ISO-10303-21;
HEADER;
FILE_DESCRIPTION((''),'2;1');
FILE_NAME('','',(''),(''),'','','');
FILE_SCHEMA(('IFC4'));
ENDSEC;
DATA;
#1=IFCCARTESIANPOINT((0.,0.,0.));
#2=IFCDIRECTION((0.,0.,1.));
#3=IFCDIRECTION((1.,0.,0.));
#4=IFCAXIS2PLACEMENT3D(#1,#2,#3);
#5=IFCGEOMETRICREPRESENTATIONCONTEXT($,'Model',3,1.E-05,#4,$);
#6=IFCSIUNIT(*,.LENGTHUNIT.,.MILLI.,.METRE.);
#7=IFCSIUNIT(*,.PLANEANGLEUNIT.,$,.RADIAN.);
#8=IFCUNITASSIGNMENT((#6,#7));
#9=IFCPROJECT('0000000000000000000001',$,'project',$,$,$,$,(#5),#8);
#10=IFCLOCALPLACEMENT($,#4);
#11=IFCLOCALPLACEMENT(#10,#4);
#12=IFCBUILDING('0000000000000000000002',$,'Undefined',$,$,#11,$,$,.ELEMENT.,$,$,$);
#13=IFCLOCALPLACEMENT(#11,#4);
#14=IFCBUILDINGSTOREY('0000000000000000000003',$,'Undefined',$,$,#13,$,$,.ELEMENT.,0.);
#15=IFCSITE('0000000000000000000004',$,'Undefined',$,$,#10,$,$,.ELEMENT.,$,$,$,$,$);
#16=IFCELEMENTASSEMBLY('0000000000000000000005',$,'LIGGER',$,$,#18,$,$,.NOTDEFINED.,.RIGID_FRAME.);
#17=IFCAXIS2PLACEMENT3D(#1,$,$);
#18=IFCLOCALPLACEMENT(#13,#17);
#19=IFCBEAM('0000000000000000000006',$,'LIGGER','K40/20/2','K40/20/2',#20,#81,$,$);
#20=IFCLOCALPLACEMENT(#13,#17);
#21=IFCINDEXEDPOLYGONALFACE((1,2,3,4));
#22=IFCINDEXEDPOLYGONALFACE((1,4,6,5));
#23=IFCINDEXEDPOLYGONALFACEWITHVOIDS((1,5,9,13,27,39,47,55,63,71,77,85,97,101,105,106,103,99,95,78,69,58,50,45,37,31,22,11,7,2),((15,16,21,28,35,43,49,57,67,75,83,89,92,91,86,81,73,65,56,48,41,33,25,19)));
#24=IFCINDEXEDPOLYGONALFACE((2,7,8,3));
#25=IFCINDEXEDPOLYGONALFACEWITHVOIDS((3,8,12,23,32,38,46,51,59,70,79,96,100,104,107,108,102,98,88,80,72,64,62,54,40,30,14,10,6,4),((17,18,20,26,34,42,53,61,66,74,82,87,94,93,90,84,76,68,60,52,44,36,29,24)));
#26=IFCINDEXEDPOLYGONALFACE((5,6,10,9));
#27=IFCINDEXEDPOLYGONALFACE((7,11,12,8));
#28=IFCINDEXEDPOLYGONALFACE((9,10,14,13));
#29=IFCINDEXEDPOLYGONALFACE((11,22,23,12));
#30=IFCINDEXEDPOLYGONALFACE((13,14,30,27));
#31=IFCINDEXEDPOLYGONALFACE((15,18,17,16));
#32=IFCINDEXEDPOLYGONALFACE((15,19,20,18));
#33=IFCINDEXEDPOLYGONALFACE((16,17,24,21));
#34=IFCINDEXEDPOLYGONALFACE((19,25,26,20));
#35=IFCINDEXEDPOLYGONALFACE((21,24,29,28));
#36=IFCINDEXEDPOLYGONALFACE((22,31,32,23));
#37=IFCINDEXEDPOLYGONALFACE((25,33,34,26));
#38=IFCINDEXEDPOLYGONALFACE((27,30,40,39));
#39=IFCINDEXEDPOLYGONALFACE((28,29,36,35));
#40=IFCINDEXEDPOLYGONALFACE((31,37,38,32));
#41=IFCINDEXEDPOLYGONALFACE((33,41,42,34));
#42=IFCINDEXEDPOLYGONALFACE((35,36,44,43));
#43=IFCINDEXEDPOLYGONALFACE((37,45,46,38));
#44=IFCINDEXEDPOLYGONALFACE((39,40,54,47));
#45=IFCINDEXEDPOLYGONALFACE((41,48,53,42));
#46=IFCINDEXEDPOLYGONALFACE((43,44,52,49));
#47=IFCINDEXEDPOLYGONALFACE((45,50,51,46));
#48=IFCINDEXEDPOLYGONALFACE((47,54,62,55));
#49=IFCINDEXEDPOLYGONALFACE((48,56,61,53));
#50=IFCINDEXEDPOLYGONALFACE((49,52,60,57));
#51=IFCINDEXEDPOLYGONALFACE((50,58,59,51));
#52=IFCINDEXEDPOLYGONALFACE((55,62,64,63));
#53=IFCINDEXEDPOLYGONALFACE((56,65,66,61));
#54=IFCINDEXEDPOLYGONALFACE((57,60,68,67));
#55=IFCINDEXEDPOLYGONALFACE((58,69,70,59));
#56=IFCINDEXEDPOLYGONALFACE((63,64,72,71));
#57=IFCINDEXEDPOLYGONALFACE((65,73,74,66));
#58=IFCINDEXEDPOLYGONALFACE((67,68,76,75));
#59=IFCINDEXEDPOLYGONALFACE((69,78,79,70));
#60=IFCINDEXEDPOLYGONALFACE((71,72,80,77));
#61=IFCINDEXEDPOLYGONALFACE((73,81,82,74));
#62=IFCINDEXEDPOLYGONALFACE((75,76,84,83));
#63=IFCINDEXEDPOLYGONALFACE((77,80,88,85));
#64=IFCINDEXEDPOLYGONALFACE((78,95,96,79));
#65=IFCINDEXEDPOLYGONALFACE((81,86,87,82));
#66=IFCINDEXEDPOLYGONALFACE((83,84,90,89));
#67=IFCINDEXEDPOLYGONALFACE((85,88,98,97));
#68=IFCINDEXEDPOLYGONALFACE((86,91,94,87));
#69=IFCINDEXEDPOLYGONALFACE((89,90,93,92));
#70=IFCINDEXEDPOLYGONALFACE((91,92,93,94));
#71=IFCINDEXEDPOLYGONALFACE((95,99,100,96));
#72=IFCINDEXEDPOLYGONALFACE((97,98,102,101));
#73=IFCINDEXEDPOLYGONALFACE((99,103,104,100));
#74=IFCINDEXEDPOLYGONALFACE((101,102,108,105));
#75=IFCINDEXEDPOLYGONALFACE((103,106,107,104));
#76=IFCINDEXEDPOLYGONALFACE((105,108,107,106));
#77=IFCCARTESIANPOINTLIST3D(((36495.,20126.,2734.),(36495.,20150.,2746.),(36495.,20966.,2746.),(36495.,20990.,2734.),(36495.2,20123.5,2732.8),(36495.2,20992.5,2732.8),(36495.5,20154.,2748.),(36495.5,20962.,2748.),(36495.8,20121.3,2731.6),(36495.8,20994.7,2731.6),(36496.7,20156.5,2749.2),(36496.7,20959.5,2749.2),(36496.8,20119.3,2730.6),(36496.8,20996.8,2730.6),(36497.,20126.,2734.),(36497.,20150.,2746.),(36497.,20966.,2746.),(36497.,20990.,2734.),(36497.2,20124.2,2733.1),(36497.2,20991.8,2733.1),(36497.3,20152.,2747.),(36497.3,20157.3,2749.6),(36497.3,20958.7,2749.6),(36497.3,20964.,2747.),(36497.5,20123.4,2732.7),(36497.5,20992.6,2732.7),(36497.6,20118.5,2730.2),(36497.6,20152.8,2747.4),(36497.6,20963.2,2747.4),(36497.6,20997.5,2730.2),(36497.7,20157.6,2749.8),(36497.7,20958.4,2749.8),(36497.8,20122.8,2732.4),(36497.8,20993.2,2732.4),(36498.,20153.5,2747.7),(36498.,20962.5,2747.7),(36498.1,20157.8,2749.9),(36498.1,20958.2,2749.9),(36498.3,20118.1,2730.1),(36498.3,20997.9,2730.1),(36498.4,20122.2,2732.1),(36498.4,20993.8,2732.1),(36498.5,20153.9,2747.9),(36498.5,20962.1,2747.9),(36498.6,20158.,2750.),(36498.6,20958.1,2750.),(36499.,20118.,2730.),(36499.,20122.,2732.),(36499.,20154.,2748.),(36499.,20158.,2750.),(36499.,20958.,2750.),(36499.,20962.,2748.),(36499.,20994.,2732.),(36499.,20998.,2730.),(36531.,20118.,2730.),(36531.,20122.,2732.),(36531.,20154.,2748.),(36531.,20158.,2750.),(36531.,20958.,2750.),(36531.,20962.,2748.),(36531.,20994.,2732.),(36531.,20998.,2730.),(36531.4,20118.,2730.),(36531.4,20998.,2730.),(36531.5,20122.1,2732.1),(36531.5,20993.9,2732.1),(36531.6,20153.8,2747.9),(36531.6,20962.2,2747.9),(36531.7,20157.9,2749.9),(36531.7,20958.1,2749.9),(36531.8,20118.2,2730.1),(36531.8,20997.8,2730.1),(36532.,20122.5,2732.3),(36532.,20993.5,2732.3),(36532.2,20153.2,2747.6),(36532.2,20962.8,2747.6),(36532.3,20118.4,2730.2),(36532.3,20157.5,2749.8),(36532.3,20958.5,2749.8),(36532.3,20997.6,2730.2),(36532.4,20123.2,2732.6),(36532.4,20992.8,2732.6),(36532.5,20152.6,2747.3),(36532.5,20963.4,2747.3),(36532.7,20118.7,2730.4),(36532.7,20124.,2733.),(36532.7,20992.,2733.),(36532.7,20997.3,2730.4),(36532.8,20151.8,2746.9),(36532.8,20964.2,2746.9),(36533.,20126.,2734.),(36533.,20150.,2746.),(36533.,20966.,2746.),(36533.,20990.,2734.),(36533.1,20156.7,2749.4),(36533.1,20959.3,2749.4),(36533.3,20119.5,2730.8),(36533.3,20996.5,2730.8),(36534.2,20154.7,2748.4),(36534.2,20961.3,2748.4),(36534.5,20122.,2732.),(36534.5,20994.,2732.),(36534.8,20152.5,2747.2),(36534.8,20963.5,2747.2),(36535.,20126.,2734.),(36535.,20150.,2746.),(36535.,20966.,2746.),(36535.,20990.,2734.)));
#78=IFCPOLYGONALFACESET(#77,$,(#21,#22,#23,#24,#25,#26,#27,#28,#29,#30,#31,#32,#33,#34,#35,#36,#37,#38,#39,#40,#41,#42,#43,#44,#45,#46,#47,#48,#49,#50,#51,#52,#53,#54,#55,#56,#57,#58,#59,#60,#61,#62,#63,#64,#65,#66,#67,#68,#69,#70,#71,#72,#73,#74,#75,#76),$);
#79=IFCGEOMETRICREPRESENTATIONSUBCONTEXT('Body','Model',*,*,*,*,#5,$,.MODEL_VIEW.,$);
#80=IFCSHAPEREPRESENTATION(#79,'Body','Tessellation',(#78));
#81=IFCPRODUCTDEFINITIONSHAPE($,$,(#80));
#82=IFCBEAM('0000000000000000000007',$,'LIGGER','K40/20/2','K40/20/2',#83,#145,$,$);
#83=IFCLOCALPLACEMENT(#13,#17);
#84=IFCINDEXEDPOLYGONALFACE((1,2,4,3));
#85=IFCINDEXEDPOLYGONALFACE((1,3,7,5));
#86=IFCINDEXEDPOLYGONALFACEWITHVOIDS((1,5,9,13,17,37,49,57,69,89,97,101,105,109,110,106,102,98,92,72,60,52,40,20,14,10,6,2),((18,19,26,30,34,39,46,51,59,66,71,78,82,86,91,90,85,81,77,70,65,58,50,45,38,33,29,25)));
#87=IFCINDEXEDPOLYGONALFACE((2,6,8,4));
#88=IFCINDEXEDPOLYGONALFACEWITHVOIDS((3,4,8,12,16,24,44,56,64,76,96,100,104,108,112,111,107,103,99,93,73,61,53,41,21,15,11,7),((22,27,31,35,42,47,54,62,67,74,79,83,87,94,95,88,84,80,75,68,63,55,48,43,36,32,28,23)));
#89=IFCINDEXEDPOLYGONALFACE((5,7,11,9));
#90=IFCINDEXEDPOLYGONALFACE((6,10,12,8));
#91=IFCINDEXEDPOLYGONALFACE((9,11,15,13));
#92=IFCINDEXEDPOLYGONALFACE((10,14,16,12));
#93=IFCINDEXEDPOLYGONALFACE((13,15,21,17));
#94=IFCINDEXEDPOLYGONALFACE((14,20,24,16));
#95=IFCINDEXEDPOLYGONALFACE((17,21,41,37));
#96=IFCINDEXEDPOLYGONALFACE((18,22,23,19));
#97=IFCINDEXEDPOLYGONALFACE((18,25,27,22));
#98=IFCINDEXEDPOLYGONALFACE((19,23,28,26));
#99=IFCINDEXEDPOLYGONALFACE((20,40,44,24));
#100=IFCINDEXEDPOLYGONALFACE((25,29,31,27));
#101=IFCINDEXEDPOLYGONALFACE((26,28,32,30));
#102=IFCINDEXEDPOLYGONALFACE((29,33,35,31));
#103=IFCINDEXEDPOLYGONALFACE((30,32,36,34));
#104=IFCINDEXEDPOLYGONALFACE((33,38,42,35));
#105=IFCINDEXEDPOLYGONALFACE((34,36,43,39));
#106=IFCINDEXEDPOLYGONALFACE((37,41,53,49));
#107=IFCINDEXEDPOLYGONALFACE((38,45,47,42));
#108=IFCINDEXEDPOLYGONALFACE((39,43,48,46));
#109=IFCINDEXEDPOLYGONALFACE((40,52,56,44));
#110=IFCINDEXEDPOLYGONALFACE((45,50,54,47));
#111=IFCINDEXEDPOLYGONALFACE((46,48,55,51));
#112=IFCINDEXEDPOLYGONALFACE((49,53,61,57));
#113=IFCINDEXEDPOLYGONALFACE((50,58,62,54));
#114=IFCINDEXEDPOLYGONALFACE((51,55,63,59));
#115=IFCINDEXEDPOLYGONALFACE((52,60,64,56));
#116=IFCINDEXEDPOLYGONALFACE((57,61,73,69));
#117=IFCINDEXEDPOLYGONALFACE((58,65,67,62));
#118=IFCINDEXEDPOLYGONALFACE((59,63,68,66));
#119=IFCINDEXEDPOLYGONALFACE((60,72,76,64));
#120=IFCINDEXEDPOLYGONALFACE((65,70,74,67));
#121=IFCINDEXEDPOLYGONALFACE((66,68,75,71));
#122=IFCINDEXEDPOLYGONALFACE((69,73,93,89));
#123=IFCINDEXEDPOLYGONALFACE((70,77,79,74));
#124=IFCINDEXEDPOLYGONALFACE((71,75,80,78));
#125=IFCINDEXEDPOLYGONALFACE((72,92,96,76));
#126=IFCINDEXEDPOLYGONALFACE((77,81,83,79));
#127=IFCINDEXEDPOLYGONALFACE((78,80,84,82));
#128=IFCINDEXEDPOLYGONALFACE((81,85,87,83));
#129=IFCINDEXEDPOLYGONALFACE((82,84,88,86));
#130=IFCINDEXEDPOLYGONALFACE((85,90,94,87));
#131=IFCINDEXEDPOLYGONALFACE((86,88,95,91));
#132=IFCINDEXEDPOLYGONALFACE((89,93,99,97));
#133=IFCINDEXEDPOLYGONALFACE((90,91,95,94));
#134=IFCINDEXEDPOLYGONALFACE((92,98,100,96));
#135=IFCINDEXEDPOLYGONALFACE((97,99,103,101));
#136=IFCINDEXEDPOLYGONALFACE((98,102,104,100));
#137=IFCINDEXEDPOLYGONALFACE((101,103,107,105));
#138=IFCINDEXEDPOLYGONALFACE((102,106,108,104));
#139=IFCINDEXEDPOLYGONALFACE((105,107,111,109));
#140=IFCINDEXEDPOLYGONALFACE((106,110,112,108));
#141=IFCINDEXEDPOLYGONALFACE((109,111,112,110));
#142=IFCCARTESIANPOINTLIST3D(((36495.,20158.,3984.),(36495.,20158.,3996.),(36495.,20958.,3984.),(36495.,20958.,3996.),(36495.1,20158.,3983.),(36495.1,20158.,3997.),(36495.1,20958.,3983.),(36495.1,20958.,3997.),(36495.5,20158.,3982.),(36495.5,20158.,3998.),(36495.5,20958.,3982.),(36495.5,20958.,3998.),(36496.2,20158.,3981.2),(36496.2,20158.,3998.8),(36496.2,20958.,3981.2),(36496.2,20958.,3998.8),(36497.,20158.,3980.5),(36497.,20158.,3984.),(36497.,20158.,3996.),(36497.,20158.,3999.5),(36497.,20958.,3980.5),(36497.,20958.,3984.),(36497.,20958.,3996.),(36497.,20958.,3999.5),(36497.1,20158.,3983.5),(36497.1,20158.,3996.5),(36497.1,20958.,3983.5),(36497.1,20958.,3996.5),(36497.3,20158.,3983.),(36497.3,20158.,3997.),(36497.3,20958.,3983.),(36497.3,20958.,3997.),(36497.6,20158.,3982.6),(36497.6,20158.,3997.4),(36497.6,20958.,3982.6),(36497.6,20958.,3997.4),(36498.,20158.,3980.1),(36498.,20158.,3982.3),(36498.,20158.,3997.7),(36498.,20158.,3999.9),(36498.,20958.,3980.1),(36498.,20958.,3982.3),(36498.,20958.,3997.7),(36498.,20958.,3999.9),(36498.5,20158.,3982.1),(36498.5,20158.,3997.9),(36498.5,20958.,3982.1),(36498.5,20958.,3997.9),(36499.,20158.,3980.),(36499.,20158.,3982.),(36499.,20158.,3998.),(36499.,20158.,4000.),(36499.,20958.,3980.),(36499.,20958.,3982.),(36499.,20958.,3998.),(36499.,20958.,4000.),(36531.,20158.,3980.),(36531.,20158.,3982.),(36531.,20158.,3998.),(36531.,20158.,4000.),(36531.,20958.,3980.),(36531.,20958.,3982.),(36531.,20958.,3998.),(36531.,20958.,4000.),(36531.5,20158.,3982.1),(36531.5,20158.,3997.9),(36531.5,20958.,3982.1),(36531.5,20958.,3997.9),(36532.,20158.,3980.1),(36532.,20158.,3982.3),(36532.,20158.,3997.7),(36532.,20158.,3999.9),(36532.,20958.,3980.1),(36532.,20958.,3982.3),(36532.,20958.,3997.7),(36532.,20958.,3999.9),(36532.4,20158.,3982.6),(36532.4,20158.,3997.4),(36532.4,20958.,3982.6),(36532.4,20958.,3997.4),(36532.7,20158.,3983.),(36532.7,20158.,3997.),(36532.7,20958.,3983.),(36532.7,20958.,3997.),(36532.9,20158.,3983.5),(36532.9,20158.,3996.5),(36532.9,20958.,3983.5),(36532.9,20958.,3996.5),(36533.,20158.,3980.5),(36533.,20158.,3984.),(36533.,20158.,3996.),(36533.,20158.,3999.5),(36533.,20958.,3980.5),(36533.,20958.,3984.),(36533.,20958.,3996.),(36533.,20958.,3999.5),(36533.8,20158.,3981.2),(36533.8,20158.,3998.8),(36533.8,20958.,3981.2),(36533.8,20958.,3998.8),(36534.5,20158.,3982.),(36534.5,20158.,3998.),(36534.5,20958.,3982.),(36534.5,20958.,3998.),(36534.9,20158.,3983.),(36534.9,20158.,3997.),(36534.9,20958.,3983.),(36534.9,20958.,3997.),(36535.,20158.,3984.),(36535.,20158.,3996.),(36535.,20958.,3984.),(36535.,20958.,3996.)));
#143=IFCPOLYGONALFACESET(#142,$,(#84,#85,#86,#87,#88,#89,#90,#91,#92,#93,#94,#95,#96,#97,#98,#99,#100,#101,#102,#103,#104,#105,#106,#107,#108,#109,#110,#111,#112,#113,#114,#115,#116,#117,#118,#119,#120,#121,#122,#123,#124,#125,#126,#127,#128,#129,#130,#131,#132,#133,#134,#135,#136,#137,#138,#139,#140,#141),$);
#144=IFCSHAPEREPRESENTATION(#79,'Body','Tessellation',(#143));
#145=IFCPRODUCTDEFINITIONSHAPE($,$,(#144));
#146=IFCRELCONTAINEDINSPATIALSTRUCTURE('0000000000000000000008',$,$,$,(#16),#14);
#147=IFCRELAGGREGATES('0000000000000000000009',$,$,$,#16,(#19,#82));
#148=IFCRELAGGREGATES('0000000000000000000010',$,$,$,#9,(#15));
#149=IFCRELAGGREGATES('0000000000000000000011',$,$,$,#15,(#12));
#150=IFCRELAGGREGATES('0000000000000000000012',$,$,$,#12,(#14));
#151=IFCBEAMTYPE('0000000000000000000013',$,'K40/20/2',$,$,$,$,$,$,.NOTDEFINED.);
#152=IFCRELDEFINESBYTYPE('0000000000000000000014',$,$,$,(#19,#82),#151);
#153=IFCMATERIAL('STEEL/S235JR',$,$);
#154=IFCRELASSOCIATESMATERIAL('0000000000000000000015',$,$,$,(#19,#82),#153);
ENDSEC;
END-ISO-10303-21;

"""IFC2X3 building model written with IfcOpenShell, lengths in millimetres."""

from ifc_helpers import new_model, si_unit, frame, origin_with_axes, origin_2d_with_axis, place, context, subcontext, project, spatial, hollow_rectangle, extrude, clip, halfspace, material, type_object, element, aggregate, save


model = new_model("IFC2X3")

# Units and contexts
model_context = context("Model", 3, precision=1e-05, world=origin_with_axes())
body_context = subcontext(model_context, "Body", "Model", "MODEL_VIEW")
ifc_project = project(units=[si_unit("LENGTHUNIT", "METRE", prefix="MILLI"), si_unit("PLANEANGLEUNIT", "RADIAN")], contexts=[model_context])

# Site, building, storey
site_placement = place(None, origin_with_axes())
site = spatial("IfcSite", under=ifc_project, at=site_placement, Name="Undefined", CompositionType="ELEMENT")
building_placement = place(site_placement, origin_with_axes())
building = spatial("IfcBuilding", under=site, at=building_placement, Name="Undefined", CompositionType="ELEMENT")
storey_placement = place(building_placement, origin_with_axes())
storey = spatial("IfcBuildingStorey", under=building, at=storey_placement, Name="Undefined", CompositionType="ELEMENT", Elevation=0.0)

# Element assembly, beams
ifc_material_1 = material(Name="STEEL/S235JR")
assembly_1_placement = place(storey_placement, origin_with_axes())
assembly_1 = element("IfcElementAssembly", 1, at=assembly_1_placement, inside=storey, Name="LIGGER", AssemblyPlace="NOTDEFINED", PredefinedType="RIGID_FRAME")
beam_type_1 = type_object("IfcBeamType", Name="K40/20/2", PredefinedType="NOTDEFINED")
beam_1_placement = place(assembly_1_placement, frame((36515.0, 20958.0, 2740.0), z_axis=(1.0, 0.0, 0.0), x_axis=(0.0, -1.0, 0.0)))
beam_1 = element("IfcBeam", 2, at=beam_1_placement, type_object=beam_type_1, material=ifc_material_1, Name="LIGGER", Description="K40/20/2", ObjectType="K40/20/2", context=body_context, shape_type="Clipping", body=[
    clip(clip(extrude(hollow_rectangle(XDim=20.0, YDim=40.0, WallThickness=2.0, InnerFilletRadius=2.0, OuterFilletRadius=4.0, at=origin_2d_with_axis()), frame((860.4, 0.0, 0.0), z_axis=(-1.0, 0.0, 0.0), x_axis=(0.0, -1.0, 0.0)), (0.0, 0.0, 1.0), 920.8), halfspace(frame((840.0, 10.0, 0.0), z_axis=(-0.447214, 0.894427, 0.0), x_axis=(0.0, 0.0, 1.0)), True)), halfspace(frame((0.0, -10.0, 0.0), z_axis=(-0.447213, -0.894427, 0.0), x_axis=(0.0, 0.0, -1.0)), False)),
])
beam_2_placement = place(assembly_1_placement, frame((36515.0, 20958.0, 3990.0), z_axis=(1.0, 0.0, 0.0), x_axis=(0.0, -1.0, 0.0)))
beam_2 = element("IfcBeam", 3, at=beam_2_placement, type_object=beam_type_1, material=ifc_material_1, Name="LIGGER", Description="K40/20/2", ObjectType="K40/20/2", context=body_context, shape_type="SweptSolid", body=[
    extrude(hollow_rectangle(XDim=20.0, YDim=40.0, WallThickness=2.0, InnerFilletRadius=2.0, OuterFilletRadius=4.0, at=origin_2d_with_axis()), frame((800.0, 0.0, 0.0), z_axis=(-1.0, 0.0, 0.0), x_axis=(0.0, -1.0, 0.0)), (0.0, 0.0, 1.0), 800.0),
])

aggregate(assembly_1, [beam_1, beam_2])

save(model, "model.ifc")
